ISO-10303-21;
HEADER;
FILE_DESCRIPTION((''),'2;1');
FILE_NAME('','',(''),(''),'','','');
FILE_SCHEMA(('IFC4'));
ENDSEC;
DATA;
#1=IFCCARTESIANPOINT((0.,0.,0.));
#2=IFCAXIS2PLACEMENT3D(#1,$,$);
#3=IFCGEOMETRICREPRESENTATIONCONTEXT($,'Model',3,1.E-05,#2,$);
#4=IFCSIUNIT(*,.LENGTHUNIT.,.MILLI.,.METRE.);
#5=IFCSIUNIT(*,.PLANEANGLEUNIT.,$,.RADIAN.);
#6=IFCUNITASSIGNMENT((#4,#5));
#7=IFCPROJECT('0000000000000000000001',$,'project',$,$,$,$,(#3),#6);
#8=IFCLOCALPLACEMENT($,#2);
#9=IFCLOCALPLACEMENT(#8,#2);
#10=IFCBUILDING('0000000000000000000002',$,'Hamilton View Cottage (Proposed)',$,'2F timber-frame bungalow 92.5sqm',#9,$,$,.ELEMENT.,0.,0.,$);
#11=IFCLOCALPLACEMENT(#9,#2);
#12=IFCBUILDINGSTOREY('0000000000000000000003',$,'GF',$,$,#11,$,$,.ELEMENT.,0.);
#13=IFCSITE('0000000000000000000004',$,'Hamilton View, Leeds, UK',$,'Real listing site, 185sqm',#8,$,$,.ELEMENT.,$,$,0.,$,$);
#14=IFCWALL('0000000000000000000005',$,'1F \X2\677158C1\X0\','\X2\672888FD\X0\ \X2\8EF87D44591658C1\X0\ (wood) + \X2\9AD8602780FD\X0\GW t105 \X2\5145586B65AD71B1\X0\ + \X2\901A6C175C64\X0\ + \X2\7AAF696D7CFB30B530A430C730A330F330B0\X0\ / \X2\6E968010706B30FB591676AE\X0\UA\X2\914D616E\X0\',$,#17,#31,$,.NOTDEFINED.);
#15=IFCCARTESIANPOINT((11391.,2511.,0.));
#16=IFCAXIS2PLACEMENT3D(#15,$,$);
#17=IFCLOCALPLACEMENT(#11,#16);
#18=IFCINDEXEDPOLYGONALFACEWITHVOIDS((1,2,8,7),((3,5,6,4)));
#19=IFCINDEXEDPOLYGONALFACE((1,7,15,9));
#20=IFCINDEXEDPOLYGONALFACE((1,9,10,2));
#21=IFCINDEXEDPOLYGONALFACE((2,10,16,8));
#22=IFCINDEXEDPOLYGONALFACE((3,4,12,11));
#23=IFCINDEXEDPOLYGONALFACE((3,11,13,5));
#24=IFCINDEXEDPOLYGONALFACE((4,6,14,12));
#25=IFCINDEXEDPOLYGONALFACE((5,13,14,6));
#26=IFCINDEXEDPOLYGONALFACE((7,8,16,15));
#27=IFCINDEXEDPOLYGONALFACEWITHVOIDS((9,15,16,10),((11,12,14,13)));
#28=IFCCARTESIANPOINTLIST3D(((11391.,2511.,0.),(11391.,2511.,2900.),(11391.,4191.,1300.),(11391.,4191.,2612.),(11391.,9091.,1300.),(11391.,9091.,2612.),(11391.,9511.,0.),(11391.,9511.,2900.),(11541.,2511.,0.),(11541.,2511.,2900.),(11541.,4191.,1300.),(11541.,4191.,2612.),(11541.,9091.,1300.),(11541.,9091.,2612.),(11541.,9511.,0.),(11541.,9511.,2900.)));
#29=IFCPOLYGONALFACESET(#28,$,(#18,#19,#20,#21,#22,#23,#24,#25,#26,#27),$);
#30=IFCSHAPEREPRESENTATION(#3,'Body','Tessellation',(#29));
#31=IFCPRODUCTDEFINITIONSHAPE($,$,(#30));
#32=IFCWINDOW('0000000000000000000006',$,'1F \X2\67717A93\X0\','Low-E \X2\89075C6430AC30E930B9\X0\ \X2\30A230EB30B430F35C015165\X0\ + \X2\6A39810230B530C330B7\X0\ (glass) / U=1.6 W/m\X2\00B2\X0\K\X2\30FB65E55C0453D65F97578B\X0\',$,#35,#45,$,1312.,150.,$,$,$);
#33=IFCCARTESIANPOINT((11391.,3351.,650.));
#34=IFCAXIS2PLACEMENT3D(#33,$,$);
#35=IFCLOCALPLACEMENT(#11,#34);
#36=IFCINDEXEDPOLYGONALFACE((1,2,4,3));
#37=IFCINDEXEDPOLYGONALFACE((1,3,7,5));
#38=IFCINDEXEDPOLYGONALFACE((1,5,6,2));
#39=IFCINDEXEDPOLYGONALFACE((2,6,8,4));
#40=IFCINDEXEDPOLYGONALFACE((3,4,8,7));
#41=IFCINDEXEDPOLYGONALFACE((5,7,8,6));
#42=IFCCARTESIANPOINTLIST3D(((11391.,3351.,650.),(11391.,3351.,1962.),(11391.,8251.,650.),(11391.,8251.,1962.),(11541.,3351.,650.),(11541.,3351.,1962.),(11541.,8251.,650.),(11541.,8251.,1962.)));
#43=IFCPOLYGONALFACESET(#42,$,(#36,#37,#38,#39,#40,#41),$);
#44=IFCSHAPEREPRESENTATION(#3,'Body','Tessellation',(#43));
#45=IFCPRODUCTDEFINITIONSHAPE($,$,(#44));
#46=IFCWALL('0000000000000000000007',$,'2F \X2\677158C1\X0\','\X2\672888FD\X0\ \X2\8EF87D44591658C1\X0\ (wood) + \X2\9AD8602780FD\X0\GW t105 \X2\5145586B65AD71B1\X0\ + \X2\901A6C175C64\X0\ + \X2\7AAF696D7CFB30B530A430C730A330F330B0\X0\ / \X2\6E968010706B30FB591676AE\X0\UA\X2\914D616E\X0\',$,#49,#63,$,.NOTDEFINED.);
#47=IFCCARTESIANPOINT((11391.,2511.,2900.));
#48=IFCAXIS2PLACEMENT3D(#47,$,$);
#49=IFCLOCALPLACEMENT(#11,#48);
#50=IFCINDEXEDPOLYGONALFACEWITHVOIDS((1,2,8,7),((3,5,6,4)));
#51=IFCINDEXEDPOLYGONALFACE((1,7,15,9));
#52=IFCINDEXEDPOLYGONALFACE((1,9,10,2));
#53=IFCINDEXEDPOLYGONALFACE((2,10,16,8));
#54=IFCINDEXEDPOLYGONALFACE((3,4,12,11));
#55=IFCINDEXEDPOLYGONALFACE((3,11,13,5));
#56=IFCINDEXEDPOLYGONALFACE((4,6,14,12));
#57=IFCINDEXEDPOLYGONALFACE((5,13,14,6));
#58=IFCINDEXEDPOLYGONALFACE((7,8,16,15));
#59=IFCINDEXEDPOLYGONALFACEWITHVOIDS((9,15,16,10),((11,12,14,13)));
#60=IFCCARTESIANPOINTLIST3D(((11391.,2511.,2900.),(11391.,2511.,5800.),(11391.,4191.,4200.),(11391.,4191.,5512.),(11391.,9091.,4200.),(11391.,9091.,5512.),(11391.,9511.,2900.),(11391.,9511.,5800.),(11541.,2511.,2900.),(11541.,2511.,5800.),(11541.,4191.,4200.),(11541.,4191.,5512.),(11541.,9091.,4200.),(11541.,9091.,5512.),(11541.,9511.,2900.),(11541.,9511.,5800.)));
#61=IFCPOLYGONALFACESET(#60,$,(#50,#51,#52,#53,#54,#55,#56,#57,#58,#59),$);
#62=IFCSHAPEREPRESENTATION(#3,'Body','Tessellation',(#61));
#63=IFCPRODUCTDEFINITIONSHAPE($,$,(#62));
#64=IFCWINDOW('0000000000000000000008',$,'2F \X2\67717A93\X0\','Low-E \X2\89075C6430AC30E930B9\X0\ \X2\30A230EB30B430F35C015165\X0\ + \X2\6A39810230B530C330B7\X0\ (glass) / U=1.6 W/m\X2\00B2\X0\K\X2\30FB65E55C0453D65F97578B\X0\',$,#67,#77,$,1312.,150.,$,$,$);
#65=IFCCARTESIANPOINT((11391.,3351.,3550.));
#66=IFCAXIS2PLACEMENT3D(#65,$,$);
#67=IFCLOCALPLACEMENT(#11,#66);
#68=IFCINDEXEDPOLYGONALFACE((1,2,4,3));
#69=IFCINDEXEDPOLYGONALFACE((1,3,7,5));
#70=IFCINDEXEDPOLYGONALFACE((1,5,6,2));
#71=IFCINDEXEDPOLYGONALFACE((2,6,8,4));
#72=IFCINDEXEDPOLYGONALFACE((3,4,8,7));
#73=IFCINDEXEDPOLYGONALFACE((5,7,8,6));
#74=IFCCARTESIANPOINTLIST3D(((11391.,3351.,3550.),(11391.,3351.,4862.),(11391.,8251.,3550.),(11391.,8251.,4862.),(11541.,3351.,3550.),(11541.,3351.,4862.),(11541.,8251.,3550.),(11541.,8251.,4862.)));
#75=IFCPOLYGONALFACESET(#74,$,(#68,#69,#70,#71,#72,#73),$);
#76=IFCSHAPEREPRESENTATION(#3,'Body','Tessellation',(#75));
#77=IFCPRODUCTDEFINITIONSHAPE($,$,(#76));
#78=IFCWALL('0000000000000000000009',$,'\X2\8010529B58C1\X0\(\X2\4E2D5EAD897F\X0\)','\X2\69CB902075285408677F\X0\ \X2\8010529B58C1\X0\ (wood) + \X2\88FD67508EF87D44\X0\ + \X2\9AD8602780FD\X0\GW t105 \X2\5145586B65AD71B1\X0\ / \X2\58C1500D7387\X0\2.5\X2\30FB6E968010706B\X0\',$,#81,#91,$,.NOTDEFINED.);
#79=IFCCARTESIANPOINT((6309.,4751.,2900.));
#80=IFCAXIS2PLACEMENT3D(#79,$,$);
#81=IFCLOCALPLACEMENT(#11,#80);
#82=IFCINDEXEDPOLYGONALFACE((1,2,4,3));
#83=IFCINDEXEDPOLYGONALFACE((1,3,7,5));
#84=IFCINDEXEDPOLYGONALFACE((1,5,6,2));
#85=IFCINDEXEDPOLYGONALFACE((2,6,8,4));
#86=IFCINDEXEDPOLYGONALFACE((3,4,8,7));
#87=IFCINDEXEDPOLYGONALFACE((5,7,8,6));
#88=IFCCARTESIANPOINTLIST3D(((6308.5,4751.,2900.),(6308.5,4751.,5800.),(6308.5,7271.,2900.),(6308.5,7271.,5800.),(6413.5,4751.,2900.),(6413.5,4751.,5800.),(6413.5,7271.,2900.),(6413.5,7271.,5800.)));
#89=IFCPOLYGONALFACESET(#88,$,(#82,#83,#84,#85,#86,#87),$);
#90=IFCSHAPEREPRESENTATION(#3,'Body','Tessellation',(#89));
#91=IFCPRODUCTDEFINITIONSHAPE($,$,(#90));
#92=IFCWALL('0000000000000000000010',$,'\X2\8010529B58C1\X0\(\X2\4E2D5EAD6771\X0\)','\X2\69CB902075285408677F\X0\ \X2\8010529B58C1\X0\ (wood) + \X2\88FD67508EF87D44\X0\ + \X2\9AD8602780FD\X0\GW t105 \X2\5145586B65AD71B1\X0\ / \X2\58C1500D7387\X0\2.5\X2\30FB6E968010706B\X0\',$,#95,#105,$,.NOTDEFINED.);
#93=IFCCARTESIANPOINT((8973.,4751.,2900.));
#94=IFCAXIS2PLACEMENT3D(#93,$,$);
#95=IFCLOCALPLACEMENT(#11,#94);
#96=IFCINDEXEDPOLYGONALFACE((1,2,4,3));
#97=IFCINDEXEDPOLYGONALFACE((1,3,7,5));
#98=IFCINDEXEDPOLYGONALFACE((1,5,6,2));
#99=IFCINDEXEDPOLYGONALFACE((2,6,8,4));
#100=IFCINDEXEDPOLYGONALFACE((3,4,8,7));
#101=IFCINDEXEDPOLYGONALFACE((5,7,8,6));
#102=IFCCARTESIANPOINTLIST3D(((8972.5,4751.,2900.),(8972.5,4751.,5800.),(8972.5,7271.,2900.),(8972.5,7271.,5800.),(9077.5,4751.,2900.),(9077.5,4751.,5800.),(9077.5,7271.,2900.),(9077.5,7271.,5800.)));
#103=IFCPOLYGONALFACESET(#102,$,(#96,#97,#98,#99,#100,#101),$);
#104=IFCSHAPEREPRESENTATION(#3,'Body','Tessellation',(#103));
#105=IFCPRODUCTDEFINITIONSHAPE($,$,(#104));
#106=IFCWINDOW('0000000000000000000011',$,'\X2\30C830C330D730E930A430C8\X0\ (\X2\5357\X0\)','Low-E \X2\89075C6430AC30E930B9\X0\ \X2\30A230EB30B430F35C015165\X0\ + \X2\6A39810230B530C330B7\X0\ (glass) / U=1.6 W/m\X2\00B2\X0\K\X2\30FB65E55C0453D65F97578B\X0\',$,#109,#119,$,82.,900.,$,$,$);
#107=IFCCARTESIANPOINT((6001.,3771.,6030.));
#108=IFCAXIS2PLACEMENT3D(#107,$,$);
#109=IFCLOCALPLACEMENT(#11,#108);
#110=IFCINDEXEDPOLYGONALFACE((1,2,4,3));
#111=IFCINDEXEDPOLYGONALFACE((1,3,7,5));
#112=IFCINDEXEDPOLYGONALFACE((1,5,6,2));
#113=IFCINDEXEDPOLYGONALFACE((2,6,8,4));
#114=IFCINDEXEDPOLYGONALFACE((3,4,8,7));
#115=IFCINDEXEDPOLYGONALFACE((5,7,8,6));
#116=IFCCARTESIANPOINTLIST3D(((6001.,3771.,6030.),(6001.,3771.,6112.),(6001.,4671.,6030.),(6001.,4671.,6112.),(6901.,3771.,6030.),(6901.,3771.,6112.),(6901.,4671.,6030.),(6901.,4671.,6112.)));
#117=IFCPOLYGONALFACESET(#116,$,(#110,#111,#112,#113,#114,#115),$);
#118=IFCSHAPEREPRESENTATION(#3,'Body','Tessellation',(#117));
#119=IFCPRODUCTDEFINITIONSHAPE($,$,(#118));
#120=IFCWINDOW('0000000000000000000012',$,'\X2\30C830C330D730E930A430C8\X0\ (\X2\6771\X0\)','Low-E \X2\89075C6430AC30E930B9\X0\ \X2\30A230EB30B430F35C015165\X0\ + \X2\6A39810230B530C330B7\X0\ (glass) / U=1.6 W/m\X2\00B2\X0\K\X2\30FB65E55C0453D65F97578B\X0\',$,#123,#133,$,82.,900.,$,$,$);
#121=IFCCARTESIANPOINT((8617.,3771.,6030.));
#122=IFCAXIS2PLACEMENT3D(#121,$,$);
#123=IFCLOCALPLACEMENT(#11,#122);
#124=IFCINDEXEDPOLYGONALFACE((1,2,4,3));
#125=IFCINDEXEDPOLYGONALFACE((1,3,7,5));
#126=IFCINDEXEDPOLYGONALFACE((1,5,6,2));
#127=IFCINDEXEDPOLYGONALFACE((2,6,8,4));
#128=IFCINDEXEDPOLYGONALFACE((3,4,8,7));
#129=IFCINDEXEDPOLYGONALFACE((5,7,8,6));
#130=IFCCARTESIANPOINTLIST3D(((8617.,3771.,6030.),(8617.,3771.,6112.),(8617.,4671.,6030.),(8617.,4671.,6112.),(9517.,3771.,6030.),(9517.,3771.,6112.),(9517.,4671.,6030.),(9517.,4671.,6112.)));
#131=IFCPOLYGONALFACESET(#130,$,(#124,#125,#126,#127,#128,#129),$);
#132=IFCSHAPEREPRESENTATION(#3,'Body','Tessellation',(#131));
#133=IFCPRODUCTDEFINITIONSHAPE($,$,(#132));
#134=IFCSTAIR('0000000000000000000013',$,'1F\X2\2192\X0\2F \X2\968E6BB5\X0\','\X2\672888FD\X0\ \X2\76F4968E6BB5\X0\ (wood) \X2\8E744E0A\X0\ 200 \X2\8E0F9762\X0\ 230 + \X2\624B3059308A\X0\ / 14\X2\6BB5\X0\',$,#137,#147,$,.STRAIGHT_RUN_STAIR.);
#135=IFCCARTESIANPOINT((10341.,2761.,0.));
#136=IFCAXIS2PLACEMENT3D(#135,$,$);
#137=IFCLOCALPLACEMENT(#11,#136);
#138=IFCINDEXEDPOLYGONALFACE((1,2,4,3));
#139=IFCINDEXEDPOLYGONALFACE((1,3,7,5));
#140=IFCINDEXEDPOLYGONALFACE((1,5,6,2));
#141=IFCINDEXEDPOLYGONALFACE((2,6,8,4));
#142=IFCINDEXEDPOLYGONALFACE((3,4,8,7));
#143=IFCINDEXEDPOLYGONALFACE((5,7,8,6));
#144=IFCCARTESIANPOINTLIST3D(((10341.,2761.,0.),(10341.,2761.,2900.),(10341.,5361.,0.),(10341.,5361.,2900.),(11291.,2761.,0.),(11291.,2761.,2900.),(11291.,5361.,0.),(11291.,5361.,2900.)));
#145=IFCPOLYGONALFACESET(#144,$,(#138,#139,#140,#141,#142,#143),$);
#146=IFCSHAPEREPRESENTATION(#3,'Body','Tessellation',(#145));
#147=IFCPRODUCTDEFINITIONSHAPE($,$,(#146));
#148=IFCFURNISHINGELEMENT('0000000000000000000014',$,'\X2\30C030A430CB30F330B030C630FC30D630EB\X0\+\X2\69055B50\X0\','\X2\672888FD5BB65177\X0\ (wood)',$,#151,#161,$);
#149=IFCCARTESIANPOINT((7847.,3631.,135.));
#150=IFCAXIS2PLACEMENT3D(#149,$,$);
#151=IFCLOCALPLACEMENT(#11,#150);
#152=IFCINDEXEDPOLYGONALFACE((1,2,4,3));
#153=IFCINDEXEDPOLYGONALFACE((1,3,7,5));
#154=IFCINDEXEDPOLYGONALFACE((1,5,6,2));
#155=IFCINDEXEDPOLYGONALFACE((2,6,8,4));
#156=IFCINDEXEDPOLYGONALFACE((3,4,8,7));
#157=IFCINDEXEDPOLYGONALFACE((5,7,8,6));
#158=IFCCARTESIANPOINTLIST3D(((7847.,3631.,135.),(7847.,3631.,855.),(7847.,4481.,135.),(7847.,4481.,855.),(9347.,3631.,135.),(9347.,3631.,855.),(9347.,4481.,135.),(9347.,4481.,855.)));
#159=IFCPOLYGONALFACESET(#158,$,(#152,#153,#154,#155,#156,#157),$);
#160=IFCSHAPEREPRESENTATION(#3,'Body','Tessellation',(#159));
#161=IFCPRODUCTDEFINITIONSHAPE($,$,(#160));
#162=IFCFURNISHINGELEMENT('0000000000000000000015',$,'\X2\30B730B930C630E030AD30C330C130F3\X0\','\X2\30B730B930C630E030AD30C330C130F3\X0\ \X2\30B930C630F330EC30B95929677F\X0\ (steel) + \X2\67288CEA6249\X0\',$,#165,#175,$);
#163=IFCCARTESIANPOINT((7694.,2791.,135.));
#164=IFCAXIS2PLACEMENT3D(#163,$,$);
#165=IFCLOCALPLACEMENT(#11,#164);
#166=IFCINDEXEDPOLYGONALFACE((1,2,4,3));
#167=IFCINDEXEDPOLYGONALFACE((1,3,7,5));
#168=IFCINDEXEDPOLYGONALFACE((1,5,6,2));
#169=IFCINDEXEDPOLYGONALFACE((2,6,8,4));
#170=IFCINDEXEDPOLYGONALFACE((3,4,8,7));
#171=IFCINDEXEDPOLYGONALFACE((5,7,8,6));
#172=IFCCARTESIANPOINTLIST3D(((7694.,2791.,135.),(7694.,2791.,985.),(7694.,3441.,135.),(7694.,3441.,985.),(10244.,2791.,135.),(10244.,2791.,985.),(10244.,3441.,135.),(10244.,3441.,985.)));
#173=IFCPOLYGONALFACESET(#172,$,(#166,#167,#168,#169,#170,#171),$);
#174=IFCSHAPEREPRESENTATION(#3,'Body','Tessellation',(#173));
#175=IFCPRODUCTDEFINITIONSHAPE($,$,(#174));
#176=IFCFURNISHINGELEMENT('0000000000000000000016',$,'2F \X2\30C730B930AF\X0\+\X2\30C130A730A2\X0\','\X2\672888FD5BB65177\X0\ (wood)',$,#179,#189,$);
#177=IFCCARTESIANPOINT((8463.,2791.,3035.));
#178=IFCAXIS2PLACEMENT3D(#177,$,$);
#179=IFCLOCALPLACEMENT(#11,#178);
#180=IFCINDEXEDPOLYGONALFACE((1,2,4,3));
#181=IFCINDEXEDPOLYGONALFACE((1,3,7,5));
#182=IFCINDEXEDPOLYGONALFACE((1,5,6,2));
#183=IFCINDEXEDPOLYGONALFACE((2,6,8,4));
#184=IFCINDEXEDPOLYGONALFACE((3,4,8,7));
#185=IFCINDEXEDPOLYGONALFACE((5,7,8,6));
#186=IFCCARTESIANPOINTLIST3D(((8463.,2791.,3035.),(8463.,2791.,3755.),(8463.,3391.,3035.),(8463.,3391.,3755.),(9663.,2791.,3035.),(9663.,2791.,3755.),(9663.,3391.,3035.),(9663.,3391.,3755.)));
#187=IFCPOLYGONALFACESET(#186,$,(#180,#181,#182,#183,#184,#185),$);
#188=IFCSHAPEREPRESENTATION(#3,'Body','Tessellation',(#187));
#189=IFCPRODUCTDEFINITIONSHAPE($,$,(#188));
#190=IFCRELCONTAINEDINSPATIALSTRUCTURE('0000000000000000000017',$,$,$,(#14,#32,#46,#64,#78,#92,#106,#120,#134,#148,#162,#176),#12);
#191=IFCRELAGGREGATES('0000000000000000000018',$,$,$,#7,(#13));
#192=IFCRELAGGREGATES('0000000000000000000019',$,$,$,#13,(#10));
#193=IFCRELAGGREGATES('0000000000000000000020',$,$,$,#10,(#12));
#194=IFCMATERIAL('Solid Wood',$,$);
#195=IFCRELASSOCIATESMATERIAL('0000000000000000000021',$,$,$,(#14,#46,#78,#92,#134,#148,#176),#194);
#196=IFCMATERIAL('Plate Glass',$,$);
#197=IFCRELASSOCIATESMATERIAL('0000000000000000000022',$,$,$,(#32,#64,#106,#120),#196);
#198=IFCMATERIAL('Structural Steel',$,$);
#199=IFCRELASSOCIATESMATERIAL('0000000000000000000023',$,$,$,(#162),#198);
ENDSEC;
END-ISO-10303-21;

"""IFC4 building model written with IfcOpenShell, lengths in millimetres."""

from ifc_helpers import new_model, si_unit, frame, frame_2d, origin, place, context, project, spatial, rectangle, extrude, material, element, fill, save


model = new_model("IFC4")

# Units and contexts
model_context = context("Model", 3, precision=1e-05, world=origin())
ifc_project = project(units=[si_unit("LENGTHUNIT", "METRE", prefix="MILLI"), si_unit("PLANEANGLEUNIT", "RADIAN")], contexts=[model_context])

# Site, building, storey
site_placement = place(None, origin())
site = spatial("IfcSite", under=ifc_project, at=site_placement, Name="Hamilton View, Leeds, UK", ObjectType="Real listing site, 185sqm", CompositionType="ELEMENT", RefElevation=0.0)
building_placement = place(site_placement, origin())
building = spatial("IfcBuilding", under=site, at=building_placement, Name="Hamilton View Cottage (Proposed)", ObjectType="2F timber-frame bungalow 92.5sqm", CompositionType="ELEMENT", ElevationOfRefHeight=0.0, ElevationOfTerrain=0.0)
storey_placement = place(building_placement, origin())
storey = spatial("IfcBuildingStorey", under=building, at=storey_placement, Name="GF", CompositionType="ELEMENT", Elevation=0.0)

# Shared definitions
ifc_material_1 = material(Name="Solid Wood")

# Wall, opening, window
wall_1_placement = place(storey_placement, frame((11391.0, 2511.0, 0.0)))
wall_1 = element("IfcWall", 1, at=wall_1_placement, inside=storey, material=ifc_material_1, Name="1F 東壁", Description="木製 軸組外壁 (wood) + 高性能GW t105 充填断熱 + 通気層 + 窯業系サイディング / 準耐火・外皮UA配慮", PredefinedType="NOTDEFINED", context=model_context, shape_type="SweptSolid", body=[
    extrude(rectangle(XDim=150.0, YDim=7000.0, at=frame_2d((75.0, 3500.0))), frame((11391.0, 2511.0, 0.0)), (0.0, 0.0, 1.0), 2900.0),
])
opening_1_placement = place(storey_placement, frame((11391.0, 3351.0, 650.0)))
opening_1 = element("IfcOpeningElement", 2, at=opening_1_placement, cuts=wall_1, PredefinedType="NOTDEFINED", context=model_context, shape_type="SweptSolid", body=[
    extrude(rectangle(XDim=150.0, YDim=4900.0, at=frame_2d((75.0, 2450.0))), frame((11391.0, 3351.0, 650.0)), (0.0, 0.0, 1.0), 1312.0),
])
ifc_material_2 = material(Name="Plate Glass")
window_1_placement = place(storey_placement, frame((11391.0, 3351.0, 650.0)))
window_1 = element("IfcWindow", 3, at=window_1_placement, inside=storey, material=ifc_material_2, Name="1F 東窓", Description="Low-E 複層ガラス アルゴン封入 + 樹脂サッシ (glass) / U=1.6 W/m²K・日射取得型", OverallHeight=1312.0, OverallWidth=150.0, context=model_context, shape_type="SweptSolid", body=[
    extrude(rectangle(XDim=150.0, YDim=4900.0, at=frame_2d((75.0, 2450.0))), frame((11391.0, 3351.0, 650.0)), (0.0, 0.0, 1.0), 1312.0),
])
fill(opening_1, window_1)

# Wall, opening, window
wall_2_placement = place(storey_placement, frame((11391.0, 2511.0, 2900.0)))
wall_2 = element("IfcWall", 4, at=wall_2_placement, inside=storey, material=ifc_material_1, Name="2F 東壁", Description="木製 軸組外壁 (wood) + 高性能GW t105 充填断熱 + 通気層 + 窯業系サイディング / 準耐火・外皮UA配慮", PredefinedType="NOTDEFINED", context=model_context, shape_type="SweptSolid", body=[
    extrude(rectangle(XDim=150.0, YDim=7000.0, at=frame_2d((75.0, 3500.0))), frame((11391.0, 2511.0, 2900.0)), (0.0, 0.0, 1.0), 2900.0),
])
opening_2_placement = place(storey_placement, frame((11391.0, 3351.0, 3550.0)))
opening_2 = element("IfcOpeningElement", 5, at=opening_2_placement, cuts=wall_2, PredefinedType="NOTDEFINED", context=model_context, shape_type="SweptSolid", body=[
    extrude(rectangle(XDim=150.0, YDim=4900.0, at=frame_2d((75.0, 2450.0))), frame((11391.0, 3351.0, 3550.0)), (0.0, 0.0, 1.0), 1312.0),
])
window_2_placement = place(storey_placement, frame((11391.0, 3351.0, 3550.0)))
window_2 = element("IfcWindow", 6, at=window_2_placement, inside=storey, material=ifc_material_2, Name="2F 東窓", Description="Low-E 複層ガラス アルゴン封入 + 樹脂サッシ (glass) / U=1.6 W/m²K・日射取得型", OverallHeight=1312.0, OverallWidth=150.0, context=model_context, shape_type="SweptSolid", body=[
    extrude(rectangle(XDim=150.0, YDim=4900.0, at=frame_2d((75.0, 2450.0))), frame((11391.0, 3351.0, 3550.0)), (0.0, 0.0, 1.0), 1312.0),
])
fill(opening_2, window_2)

# Walls
wall_3_placement = place(storey_placement, frame((6309.0, 4751.0, 2900.0)))
element("IfcWall", 7, at=wall_3_placement, inside=storey, material=ifc_material_1, Name="耐力壁(中庭西)", Description="構造用合板 耐力壁 (wood) + 製材軸組 + 高性能GW t105 充填断熱 / 壁倍率2.5・準耐火", PredefinedType="NOTDEFINED", context=model_context, shape_type="SweptSolid", body=[
    extrude(rectangle(XDim=105.0, YDim=2520.0, at=frame_2d((52.0, 1260.0))), frame((6309.0, 4751.0, 2900.0)), (0.0, 0.0, 1.0), 2900.0),
])
wall_4_placement = place(storey_placement, frame((8973.0, 4751.0, 2900.0)))
element("IfcWall", 8, at=wall_4_placement, inside=storey, material=ifc_material_1, Name="耐力壁(中庭東)", Description="構造用合板 耐力壁 (wood) + 製材軸組 + 高性能GW t105 充填断熱 / 壁倍率2.5・準耐火", PredefinedType="NOTDEFINED", context=model_context, shape_type="SweptSolid", body=[
    extrude(rectangle(XDim=105.0, YDim=2520.0, at=frame_2d((52.0, 1260.0))), frame((8973.0, 4751.0, 2900.0)), (0.0, 0.0, 1.0), 2900.0),
])

# Windows
window_3_placement = place(storey_placement, frame((6001.0, 3771.0, 6030.0)))
element("IfcWindow", 9, at=window_3_placement, inside=storey, material=ifc_material_2, Name="トップライト (南)", Description="Low-E 複層ガラス アルゴン封入 + 樹脂サッシ (glass) / U=1.6 W/m²K・日射取得型", OverallHeight=82.0, OverallWidth=900.0, context=model_context, shape_type="SweptSolid", body=[
    extrude(rectangle(XDim=900.0, YDim=900.0, at=frame_2d((450.0, 450.0))), frame((6001.0, 3771.0, 6030.0)), (0.0, 0.0, 1.0), 82.0),
])
window_4_placement = place(storey_placement, frame((8617.0, 3771.0, 6030.0)))
element("IfcWindow", 10, at=window_4_placement, inside=storey, material=ifc_material_2, Name="トップライト (東)", Description="Low-E 複層ガラス アルゴン封入 + 樹脂サッシ (glass) / U=1.6 W/m²K・日射取得型", OverallHeight=82.0, OverallWidth=900.0, context=model_context, shape_type="SweptSolid", body=[
    extrude(rectangle(XDim=900.0, YDim=900.0, at=frame_2d((450.0, 450.0))), frame((8617.0, 3771.0, 6030.0)), (0.0, 0.0, 1.0), 82.0),
])

# Stair
stair_placement = place(storey_placement, frame((10341.0, 2761.0, 0.0)))
element("IfcStair", 11, at=stair_placement, inside=storey, material=ifc_material_1, Name="1F→2F 階段", Description="木製 直階段 (wood) 蹴上 200 踏面 230 + 手すり / 14段", PredefinedType="STRAIGHT_RUN_STAIR", context=model_context, shape_type="SweptSolid", body=[
    extrude(rectangle(XDim=950.0, YDim=2600.0, at=frame_2d((475.0, 1300.0))), frame((10341.0, 2761.0, 0.0)), (0.0, 0.0, 1.0), 2900.0),
])

# Furnishing elements
furnishing_1_placement = place(storey_placement, frame((7847.0, 3631.0, 135.0)))
element("IfcFurnishingElement", 12, at=furnishing_1_placement, inside=storey, material=ifc_material_1, Name="ダイニングテーブル+椅子", Description="木製家具 (wood)", context=model_context, shape_type="SweptSolid", body=[
    extrude(rectangle(XDim=1500.0, YDim=850.0, at=frame_2d((750.0, 425.0))), frame((7847.0, 3631.0, 135.0)), (0.0, 0.0, 1.0), 720.0),
])
ifc_material_3 = material(Name="Structural Steel")
furnishing_2_placement = place(storey_placement, frame((7694.0, 2791.0, 135.0)))
element("IfcFurnishingElement", 13, at=furnishing_2_placement, inside=storey, material=ifc_material_3, Name="システムキッチン", Description="システムキッチン ステンレス天板 (steel) + 木質扉", context=model_context, shape_type="SweptSolid", body=[
    extrude(rectangle(XDim=2550.0, YDim=650.0, at=frame_2d((1275.0, 325.0))), frame((7694.0, 2791.0, 135.0)), (0.0, 0.0, 1.0), 850.0),
])
furnishing_3_placement = place(storey_placement, frame((8463.0, 2791.0, 3035.0)))
element("IfcFurnishingElement", 14, at=furnishing_3_placement, inside=storey, material=ifc_material_1, Name="2F デスク+チェア", Description="木製家具 (wood)", context=model_context, shape_type="SweptSolid", body=[
    extrude(rectangle(XDim=1200.0, YDim=600.0, at=frame_2d((600.0, 300.0))), frame((8463.0, 2791.0, 3035.0)), (0.0, 0.0, 1.0), 720.0),
])

save(model, "model.ifc")
